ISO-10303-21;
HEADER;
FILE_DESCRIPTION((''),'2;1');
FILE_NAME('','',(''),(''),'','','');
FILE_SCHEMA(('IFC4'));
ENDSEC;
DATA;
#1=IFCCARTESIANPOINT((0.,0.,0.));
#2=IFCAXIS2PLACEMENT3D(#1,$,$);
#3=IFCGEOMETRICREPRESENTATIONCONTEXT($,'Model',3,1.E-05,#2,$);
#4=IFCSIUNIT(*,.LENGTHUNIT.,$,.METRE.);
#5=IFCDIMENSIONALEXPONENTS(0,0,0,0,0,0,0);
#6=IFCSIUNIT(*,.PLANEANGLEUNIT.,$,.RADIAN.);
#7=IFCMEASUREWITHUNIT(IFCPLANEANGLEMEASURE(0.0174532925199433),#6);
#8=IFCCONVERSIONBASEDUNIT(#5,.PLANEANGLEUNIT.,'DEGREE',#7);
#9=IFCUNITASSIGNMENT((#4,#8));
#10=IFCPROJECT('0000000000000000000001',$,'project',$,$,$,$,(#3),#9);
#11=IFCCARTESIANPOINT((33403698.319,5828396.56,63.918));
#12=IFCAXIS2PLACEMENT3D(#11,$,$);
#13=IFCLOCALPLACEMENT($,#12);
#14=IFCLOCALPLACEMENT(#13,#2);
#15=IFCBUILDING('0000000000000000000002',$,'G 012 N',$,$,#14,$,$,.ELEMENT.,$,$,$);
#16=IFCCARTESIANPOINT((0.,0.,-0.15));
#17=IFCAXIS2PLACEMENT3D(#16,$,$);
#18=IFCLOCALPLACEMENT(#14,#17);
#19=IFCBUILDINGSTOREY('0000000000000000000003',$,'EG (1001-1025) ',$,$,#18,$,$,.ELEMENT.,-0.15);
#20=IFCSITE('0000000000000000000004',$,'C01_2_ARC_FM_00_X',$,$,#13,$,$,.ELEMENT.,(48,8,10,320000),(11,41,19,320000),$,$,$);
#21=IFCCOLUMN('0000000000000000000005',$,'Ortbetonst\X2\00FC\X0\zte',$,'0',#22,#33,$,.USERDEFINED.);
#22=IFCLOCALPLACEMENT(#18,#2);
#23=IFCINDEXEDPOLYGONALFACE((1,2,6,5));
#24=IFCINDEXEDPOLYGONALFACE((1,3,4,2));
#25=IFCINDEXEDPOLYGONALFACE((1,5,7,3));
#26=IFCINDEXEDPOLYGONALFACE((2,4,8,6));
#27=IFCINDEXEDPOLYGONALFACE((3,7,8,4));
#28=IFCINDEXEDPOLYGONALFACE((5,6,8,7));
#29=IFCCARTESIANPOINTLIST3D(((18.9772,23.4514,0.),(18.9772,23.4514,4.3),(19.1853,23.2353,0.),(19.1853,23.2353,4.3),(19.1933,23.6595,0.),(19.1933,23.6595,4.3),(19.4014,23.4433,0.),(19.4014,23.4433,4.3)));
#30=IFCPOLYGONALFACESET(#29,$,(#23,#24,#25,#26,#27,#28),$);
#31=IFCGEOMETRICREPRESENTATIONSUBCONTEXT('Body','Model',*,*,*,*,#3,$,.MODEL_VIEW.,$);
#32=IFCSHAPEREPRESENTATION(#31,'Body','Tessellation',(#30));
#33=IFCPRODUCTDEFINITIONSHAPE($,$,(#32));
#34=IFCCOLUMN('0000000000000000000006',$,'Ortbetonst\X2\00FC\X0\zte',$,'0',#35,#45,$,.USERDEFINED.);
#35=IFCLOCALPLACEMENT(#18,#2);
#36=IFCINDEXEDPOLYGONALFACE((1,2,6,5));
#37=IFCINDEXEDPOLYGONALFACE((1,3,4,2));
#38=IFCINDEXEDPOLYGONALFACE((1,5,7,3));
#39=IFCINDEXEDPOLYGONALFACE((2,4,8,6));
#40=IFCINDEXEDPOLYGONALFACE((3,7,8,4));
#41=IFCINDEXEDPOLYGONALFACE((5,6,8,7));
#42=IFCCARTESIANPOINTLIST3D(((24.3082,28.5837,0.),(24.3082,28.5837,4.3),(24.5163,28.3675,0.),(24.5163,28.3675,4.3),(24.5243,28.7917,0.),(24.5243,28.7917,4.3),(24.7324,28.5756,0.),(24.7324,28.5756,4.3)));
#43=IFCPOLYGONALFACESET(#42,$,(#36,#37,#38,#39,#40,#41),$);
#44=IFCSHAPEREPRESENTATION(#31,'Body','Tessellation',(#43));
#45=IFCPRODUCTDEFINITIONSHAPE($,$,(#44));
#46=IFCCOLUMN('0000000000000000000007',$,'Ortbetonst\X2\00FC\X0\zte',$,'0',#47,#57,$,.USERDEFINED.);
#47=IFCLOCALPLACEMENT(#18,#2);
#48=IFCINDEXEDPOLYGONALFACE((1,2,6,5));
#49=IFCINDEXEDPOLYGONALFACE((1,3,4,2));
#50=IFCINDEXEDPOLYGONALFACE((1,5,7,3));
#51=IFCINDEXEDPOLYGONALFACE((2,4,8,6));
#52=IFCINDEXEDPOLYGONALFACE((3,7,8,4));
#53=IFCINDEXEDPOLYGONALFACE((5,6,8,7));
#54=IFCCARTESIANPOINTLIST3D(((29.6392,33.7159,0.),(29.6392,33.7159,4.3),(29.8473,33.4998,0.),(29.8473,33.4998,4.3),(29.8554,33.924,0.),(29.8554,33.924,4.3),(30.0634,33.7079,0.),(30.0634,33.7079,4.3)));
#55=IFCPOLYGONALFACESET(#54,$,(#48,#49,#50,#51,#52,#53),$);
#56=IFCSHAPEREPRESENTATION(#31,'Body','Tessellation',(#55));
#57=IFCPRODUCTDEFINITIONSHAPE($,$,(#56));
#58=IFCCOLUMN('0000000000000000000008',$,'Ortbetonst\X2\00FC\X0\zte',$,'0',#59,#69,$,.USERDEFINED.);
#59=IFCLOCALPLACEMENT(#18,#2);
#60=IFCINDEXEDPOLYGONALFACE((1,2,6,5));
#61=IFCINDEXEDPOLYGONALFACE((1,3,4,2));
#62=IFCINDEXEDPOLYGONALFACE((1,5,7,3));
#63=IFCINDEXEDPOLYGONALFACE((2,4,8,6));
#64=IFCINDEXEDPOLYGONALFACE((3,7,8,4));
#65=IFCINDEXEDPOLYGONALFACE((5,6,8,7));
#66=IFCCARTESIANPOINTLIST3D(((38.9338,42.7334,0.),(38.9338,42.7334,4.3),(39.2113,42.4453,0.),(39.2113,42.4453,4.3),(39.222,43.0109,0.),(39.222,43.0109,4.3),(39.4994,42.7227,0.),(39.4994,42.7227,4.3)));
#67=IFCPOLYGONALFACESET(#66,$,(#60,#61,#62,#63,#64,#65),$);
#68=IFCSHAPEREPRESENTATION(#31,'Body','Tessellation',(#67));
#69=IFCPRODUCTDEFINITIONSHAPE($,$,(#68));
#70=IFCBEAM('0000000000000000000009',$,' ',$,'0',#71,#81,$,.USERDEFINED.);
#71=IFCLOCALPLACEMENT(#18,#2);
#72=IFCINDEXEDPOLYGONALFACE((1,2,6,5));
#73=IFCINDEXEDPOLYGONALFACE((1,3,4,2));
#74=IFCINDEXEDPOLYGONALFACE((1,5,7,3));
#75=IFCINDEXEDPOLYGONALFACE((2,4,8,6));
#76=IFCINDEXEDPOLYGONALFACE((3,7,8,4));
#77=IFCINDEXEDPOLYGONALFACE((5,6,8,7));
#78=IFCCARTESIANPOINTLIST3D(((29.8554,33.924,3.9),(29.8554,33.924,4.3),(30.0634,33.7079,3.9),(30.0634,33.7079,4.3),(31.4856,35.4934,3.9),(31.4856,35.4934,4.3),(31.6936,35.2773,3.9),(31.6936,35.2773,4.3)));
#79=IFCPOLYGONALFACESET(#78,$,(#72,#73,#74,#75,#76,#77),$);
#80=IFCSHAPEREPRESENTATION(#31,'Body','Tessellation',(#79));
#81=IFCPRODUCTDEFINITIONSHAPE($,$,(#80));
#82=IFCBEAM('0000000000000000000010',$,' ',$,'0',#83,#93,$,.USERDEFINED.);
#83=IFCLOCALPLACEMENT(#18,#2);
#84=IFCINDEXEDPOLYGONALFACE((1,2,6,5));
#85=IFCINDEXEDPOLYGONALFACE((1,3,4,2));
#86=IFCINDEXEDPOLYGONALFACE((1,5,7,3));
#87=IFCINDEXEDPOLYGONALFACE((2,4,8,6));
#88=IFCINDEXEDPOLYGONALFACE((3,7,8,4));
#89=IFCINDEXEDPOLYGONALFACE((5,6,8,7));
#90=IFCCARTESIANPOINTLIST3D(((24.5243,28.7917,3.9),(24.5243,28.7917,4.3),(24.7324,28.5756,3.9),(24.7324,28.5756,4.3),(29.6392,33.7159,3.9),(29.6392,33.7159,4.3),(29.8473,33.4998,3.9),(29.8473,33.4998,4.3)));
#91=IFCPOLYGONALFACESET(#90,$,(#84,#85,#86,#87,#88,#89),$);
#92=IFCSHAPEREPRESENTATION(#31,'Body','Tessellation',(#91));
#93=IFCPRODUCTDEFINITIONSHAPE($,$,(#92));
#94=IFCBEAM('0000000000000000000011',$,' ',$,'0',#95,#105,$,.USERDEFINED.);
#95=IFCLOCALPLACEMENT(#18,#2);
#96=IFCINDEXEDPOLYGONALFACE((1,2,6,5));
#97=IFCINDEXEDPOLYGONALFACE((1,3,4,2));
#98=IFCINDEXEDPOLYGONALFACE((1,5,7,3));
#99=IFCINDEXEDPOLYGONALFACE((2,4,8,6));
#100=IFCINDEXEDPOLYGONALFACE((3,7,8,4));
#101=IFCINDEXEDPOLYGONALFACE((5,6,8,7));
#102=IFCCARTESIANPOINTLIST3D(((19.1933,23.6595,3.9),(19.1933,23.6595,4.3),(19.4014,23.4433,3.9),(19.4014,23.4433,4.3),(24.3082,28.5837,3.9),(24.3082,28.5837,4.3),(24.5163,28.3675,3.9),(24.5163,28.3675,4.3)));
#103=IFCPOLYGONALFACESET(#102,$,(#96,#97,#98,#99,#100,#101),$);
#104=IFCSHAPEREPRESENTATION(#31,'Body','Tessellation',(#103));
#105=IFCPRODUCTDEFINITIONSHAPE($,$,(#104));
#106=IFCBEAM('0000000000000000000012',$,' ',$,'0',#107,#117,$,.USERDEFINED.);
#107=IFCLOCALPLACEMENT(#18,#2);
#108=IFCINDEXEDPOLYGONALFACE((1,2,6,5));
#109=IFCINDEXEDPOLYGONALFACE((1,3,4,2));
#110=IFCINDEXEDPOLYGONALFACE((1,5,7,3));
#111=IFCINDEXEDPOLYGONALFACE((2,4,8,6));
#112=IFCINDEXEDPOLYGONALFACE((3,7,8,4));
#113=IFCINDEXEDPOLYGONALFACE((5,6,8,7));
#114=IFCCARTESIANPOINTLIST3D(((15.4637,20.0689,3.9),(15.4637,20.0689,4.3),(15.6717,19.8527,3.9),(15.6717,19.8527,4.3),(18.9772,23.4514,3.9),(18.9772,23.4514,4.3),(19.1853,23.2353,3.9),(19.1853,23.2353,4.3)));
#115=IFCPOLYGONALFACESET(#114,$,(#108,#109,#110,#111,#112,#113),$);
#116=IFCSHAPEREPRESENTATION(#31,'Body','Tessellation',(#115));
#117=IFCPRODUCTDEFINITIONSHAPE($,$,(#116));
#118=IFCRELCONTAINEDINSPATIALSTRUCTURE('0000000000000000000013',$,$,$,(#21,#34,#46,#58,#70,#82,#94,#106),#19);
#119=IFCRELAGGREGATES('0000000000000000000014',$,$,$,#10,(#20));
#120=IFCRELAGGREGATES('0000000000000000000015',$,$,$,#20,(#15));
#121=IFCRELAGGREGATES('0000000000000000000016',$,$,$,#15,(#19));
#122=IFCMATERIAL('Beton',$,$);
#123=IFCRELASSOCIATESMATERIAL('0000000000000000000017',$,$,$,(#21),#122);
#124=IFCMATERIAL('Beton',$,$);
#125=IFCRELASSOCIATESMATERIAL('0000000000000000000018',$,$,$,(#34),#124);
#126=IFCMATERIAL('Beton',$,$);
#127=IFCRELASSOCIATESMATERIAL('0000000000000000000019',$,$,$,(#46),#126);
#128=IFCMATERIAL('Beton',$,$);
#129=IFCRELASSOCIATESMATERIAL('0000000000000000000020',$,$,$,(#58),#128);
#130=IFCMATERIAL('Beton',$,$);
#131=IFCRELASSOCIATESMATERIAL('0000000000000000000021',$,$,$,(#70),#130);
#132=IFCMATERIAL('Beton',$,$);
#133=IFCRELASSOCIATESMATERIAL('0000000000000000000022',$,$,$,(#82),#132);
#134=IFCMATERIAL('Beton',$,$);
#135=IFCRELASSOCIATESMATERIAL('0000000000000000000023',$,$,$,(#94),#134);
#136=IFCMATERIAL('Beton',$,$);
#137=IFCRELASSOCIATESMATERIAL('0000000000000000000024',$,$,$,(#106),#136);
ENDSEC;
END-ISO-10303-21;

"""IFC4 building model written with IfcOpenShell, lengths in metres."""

from ifc_helpers import new_model, entity, si_unit, converted_unit, frame, frame_2d, origin, origin_with_axes, place, context, subcontext, project, spatial, rectangle, extrude, material, element, save


model = new_model("IFC4")

# Units and contexts
model_context = context("Model", 3, precision=1e-05, world=origin())
body_context = subcontext(model_context, "Body", "Model", "MODEL_VIEW")
ifc_project = project(units=[si_unit("LENGTHUNIT", "METRE"), converted_unit("PLANEANGLEUNIT", "DEGREE", entity("IfcPlaneAngleMeasure", 0.0174532925199433), si_unit("PLANEANGLEUNIT", "RADIAN"), dimensions=[0, 0, 0, 0, 0, 0, 0])], contexts=[model_context])

# Site, building, storey
site_placement = place(None, frame((33403698.319, 5828396.56, 63.918)))
site = spatial("IfcSite", under=ifc_project, at=site_placement, Name="C01_2_ARC_FM_00_X", CompositionType="ELEMENT", RefLatitude=(48, 8, 10, 320000), RefLongitude=(11, 41, 19, 320000))
building_placement = place(site_placement, origin())
building = spatial("IfcBuilding", under=site, at=building_placement, Name="G 012 N", CompositionType="ELEMENT")
storey_placement = place(building_placement, frame((0.0, 0.0, -0.15)))
storey = spatial("IfcBuildingStorey", under=building, at=storey_placement, Name="EG (1001-1025) ", CompositionType="ELEMENT", Elevation=-0.15)

# Columns
ifc_material_1 = material(Name="Beton")
column_1_placement = place(storey_placement, frame((19.1853, 23.2353, 0.0)))
element("IfcColumn", 1, at=column_1_placement, inside=storey, material=ifc_material_1, Name="Ortbetonstüzte", ObjectType="0", PredefinedType="USERDEFINED", context=body_context, shape_type="SweptSolid", body=[
    extrude(rectangle(XDim=0.3, YDim=0.3, at=frame_2d((0.004, 0.2121), x_axis=(0.720408, 0.693551))), origin_with_axes(), (0.0, 0.0, 1.0), 4.3),
])
ifc_material_2 = material(Name="Beton")
column_2_placement = place(storey_placement, frame((24.5163, 28.3675, 0.0)))
element("IfcColumn", 2, at=column_2_placement, inside=storey, material=ifc_material_2, Name="Ortbetonstüzte", ObjectType="0", PredefinedType="USERDEFINED", context=body_context, shape_type="SweptSolid", body=[
    extrude(rectangle(XDim=0.3, YDim=0.3, at=frame_2d((0.004, 0.2121), x_axis=(0.720408, 0.693551))), origin_with_axes(), (0.0, 0.0, 1.0), 4.3),
])
ifc_material_3 = material(Name="Beton")
column_3_placement = place(storey_placement, frame((29.8473, 33.4998, 0.0)))
element("IfcColumn", 3, at=column_3_placement, inside=storey, material=ifc_material_3, Name="Ortbetonstüzte", ObjectType="0", PredefinedType="USERDEFINED", context=body_context, shape_type="SweptSolid", body=[
    extrude(rectangle(XDim=0.3, YDim=0.3, at=frame_2d((0.004, 0.2121), x_axis=(0.720408, 0.693551))), origin_with_axes(), (0.0, 0.0, 1.0), 4.3),
])
ifc_material_4 = material(Name="Beton")
column_4_placement = place(storey_placement, frame((39.2113, 42.4453, 0.0)))
element("IfcColumn", 4, at=column_4_placement, inside=storey, material=ifc_material_4, Name="Ortbetonstüzte", ObjectType="0", PredefinedType="USERDEFINED", context=body_context, shape_type="SweptSolid", body=[
    extrude(rectangle(XDim=0.4, YDim=0.4, at=frame_2d((0.0054, 0.2828), x_axis=(0.720408, 0.693551))), origin_with_axes(), (0.0, 0.0, 1.0), 4.3),
])

# Beams
ifc_material_5 = material(Name="Beton")
beam_1_placement = place(storey_placement, frame((30.0634, 33.7079, 3.9), z_axis=(0.0, 0.0, 1.0), x_axis=(0.720408, 0.693551, 0.0)))
element("IfcBeam", 5, at=beam_1_placement, inside=storey, material=ifc_material_5, Name=" ", ObjectType="0", PredefinedType="USERDEFINED", context=body_context, shape_type="SweptSolid", body=[
    extrude(rectangle(XDim=0.3, YDim=0.4, at=frame_2d((0.15, 0.2), x_axis=(1.0, 0.0))), frame((0.0, 0.0, 0.0), z_axis=(1.0, 0.0, 0.0), x_axis=(0.0, 1.0, 0.0)), (0.0, 0.0, 1.0), 2.2629),
])
ifc_material_6 = material(Name="Beton")
beam_2_placement = place(storey_placement, frame((24.7324, 28.5756, 3.9), z_axis=(0.0, 0.0, 1.0), x_axis=(0.720408, 0.693551, 0.0)))
element("IfcBeam", 6, at=beam_2_placement, inside=storey, material=ifc_material_6, Name=" ", ObjectType="0", PredefinedType="USERDEFINED", context=body_context, shape_type="SweptSolid", body=[
    extrude(rectangle(XDim=0.3, YDim=0.4, at=frame_2d((0.15, 0.2), x_axis=(1.0, 0.0))), frame((0.0, 0.0, 0.0), z_axis=(1.0, 0.0, 0.0), x_axis=(0.0, 1.0, 0.0)), (0.0, 0.0, 1.0), 7.1),
])
ifc_material_7 = material(Name="Beton")
beam_3_placement = place(storey_placement, frame((19.4014, 23.4433, 3.9), z_axis=(0.0, 0.0, 1.0), x_axis=(0.720408, 0.693551, 0.0)))
element("IfcBeam", 7, at=beam_3_placement, inside=storey, material=ifc_material_7, Name=" ", ObjectType="0", PredefinedType="USERDEFINED", context=body_context, shape_type="SweptSolid", body=[
    extrude(rectangle(XDim=0.3, YDim=0.4, at=frame_2d((0.15, 0.2), x_axis=(1.0, 0.0))), frame((0.0, 0.0, 0.0), z_axis=(1.0, 0.0, 0.0), x_axis=(0.0, 1.0, 0.0)), (0.0, 0.0, 1.0), 7.1),
])
ifc_material_8 = material(Name="Beton")
beam_4_placement = place(storey_placement, frame((18.9772, 23.4514, 3.9), z_axis=(0.0, 0.0, 1.0), x_axis=(-0.720408, -0.693551, 0.0)))
element("IfcBeam", 8, at=beam_4_placement, inside=storey, material=ifc_material_8, Name=" ", ObjectType="0", PredefinedType="USERDEFINED", context=body_context, shape_type="SweptSolid", body=[
    extrude(rectangle(XDim=0.3, YDim=0.4, at=frame_2d((0.15, 0.2), x_axis=(1.0, 0.0))), frame((0.0, 0.0, 0.0), z_axis=(1.0, 0.0, 0.0), x_axis=(0.0, 1.0, 0.0)), (0.0, 0.0, 1.0), 4.8771),
])

save(model, "model.ifc")
